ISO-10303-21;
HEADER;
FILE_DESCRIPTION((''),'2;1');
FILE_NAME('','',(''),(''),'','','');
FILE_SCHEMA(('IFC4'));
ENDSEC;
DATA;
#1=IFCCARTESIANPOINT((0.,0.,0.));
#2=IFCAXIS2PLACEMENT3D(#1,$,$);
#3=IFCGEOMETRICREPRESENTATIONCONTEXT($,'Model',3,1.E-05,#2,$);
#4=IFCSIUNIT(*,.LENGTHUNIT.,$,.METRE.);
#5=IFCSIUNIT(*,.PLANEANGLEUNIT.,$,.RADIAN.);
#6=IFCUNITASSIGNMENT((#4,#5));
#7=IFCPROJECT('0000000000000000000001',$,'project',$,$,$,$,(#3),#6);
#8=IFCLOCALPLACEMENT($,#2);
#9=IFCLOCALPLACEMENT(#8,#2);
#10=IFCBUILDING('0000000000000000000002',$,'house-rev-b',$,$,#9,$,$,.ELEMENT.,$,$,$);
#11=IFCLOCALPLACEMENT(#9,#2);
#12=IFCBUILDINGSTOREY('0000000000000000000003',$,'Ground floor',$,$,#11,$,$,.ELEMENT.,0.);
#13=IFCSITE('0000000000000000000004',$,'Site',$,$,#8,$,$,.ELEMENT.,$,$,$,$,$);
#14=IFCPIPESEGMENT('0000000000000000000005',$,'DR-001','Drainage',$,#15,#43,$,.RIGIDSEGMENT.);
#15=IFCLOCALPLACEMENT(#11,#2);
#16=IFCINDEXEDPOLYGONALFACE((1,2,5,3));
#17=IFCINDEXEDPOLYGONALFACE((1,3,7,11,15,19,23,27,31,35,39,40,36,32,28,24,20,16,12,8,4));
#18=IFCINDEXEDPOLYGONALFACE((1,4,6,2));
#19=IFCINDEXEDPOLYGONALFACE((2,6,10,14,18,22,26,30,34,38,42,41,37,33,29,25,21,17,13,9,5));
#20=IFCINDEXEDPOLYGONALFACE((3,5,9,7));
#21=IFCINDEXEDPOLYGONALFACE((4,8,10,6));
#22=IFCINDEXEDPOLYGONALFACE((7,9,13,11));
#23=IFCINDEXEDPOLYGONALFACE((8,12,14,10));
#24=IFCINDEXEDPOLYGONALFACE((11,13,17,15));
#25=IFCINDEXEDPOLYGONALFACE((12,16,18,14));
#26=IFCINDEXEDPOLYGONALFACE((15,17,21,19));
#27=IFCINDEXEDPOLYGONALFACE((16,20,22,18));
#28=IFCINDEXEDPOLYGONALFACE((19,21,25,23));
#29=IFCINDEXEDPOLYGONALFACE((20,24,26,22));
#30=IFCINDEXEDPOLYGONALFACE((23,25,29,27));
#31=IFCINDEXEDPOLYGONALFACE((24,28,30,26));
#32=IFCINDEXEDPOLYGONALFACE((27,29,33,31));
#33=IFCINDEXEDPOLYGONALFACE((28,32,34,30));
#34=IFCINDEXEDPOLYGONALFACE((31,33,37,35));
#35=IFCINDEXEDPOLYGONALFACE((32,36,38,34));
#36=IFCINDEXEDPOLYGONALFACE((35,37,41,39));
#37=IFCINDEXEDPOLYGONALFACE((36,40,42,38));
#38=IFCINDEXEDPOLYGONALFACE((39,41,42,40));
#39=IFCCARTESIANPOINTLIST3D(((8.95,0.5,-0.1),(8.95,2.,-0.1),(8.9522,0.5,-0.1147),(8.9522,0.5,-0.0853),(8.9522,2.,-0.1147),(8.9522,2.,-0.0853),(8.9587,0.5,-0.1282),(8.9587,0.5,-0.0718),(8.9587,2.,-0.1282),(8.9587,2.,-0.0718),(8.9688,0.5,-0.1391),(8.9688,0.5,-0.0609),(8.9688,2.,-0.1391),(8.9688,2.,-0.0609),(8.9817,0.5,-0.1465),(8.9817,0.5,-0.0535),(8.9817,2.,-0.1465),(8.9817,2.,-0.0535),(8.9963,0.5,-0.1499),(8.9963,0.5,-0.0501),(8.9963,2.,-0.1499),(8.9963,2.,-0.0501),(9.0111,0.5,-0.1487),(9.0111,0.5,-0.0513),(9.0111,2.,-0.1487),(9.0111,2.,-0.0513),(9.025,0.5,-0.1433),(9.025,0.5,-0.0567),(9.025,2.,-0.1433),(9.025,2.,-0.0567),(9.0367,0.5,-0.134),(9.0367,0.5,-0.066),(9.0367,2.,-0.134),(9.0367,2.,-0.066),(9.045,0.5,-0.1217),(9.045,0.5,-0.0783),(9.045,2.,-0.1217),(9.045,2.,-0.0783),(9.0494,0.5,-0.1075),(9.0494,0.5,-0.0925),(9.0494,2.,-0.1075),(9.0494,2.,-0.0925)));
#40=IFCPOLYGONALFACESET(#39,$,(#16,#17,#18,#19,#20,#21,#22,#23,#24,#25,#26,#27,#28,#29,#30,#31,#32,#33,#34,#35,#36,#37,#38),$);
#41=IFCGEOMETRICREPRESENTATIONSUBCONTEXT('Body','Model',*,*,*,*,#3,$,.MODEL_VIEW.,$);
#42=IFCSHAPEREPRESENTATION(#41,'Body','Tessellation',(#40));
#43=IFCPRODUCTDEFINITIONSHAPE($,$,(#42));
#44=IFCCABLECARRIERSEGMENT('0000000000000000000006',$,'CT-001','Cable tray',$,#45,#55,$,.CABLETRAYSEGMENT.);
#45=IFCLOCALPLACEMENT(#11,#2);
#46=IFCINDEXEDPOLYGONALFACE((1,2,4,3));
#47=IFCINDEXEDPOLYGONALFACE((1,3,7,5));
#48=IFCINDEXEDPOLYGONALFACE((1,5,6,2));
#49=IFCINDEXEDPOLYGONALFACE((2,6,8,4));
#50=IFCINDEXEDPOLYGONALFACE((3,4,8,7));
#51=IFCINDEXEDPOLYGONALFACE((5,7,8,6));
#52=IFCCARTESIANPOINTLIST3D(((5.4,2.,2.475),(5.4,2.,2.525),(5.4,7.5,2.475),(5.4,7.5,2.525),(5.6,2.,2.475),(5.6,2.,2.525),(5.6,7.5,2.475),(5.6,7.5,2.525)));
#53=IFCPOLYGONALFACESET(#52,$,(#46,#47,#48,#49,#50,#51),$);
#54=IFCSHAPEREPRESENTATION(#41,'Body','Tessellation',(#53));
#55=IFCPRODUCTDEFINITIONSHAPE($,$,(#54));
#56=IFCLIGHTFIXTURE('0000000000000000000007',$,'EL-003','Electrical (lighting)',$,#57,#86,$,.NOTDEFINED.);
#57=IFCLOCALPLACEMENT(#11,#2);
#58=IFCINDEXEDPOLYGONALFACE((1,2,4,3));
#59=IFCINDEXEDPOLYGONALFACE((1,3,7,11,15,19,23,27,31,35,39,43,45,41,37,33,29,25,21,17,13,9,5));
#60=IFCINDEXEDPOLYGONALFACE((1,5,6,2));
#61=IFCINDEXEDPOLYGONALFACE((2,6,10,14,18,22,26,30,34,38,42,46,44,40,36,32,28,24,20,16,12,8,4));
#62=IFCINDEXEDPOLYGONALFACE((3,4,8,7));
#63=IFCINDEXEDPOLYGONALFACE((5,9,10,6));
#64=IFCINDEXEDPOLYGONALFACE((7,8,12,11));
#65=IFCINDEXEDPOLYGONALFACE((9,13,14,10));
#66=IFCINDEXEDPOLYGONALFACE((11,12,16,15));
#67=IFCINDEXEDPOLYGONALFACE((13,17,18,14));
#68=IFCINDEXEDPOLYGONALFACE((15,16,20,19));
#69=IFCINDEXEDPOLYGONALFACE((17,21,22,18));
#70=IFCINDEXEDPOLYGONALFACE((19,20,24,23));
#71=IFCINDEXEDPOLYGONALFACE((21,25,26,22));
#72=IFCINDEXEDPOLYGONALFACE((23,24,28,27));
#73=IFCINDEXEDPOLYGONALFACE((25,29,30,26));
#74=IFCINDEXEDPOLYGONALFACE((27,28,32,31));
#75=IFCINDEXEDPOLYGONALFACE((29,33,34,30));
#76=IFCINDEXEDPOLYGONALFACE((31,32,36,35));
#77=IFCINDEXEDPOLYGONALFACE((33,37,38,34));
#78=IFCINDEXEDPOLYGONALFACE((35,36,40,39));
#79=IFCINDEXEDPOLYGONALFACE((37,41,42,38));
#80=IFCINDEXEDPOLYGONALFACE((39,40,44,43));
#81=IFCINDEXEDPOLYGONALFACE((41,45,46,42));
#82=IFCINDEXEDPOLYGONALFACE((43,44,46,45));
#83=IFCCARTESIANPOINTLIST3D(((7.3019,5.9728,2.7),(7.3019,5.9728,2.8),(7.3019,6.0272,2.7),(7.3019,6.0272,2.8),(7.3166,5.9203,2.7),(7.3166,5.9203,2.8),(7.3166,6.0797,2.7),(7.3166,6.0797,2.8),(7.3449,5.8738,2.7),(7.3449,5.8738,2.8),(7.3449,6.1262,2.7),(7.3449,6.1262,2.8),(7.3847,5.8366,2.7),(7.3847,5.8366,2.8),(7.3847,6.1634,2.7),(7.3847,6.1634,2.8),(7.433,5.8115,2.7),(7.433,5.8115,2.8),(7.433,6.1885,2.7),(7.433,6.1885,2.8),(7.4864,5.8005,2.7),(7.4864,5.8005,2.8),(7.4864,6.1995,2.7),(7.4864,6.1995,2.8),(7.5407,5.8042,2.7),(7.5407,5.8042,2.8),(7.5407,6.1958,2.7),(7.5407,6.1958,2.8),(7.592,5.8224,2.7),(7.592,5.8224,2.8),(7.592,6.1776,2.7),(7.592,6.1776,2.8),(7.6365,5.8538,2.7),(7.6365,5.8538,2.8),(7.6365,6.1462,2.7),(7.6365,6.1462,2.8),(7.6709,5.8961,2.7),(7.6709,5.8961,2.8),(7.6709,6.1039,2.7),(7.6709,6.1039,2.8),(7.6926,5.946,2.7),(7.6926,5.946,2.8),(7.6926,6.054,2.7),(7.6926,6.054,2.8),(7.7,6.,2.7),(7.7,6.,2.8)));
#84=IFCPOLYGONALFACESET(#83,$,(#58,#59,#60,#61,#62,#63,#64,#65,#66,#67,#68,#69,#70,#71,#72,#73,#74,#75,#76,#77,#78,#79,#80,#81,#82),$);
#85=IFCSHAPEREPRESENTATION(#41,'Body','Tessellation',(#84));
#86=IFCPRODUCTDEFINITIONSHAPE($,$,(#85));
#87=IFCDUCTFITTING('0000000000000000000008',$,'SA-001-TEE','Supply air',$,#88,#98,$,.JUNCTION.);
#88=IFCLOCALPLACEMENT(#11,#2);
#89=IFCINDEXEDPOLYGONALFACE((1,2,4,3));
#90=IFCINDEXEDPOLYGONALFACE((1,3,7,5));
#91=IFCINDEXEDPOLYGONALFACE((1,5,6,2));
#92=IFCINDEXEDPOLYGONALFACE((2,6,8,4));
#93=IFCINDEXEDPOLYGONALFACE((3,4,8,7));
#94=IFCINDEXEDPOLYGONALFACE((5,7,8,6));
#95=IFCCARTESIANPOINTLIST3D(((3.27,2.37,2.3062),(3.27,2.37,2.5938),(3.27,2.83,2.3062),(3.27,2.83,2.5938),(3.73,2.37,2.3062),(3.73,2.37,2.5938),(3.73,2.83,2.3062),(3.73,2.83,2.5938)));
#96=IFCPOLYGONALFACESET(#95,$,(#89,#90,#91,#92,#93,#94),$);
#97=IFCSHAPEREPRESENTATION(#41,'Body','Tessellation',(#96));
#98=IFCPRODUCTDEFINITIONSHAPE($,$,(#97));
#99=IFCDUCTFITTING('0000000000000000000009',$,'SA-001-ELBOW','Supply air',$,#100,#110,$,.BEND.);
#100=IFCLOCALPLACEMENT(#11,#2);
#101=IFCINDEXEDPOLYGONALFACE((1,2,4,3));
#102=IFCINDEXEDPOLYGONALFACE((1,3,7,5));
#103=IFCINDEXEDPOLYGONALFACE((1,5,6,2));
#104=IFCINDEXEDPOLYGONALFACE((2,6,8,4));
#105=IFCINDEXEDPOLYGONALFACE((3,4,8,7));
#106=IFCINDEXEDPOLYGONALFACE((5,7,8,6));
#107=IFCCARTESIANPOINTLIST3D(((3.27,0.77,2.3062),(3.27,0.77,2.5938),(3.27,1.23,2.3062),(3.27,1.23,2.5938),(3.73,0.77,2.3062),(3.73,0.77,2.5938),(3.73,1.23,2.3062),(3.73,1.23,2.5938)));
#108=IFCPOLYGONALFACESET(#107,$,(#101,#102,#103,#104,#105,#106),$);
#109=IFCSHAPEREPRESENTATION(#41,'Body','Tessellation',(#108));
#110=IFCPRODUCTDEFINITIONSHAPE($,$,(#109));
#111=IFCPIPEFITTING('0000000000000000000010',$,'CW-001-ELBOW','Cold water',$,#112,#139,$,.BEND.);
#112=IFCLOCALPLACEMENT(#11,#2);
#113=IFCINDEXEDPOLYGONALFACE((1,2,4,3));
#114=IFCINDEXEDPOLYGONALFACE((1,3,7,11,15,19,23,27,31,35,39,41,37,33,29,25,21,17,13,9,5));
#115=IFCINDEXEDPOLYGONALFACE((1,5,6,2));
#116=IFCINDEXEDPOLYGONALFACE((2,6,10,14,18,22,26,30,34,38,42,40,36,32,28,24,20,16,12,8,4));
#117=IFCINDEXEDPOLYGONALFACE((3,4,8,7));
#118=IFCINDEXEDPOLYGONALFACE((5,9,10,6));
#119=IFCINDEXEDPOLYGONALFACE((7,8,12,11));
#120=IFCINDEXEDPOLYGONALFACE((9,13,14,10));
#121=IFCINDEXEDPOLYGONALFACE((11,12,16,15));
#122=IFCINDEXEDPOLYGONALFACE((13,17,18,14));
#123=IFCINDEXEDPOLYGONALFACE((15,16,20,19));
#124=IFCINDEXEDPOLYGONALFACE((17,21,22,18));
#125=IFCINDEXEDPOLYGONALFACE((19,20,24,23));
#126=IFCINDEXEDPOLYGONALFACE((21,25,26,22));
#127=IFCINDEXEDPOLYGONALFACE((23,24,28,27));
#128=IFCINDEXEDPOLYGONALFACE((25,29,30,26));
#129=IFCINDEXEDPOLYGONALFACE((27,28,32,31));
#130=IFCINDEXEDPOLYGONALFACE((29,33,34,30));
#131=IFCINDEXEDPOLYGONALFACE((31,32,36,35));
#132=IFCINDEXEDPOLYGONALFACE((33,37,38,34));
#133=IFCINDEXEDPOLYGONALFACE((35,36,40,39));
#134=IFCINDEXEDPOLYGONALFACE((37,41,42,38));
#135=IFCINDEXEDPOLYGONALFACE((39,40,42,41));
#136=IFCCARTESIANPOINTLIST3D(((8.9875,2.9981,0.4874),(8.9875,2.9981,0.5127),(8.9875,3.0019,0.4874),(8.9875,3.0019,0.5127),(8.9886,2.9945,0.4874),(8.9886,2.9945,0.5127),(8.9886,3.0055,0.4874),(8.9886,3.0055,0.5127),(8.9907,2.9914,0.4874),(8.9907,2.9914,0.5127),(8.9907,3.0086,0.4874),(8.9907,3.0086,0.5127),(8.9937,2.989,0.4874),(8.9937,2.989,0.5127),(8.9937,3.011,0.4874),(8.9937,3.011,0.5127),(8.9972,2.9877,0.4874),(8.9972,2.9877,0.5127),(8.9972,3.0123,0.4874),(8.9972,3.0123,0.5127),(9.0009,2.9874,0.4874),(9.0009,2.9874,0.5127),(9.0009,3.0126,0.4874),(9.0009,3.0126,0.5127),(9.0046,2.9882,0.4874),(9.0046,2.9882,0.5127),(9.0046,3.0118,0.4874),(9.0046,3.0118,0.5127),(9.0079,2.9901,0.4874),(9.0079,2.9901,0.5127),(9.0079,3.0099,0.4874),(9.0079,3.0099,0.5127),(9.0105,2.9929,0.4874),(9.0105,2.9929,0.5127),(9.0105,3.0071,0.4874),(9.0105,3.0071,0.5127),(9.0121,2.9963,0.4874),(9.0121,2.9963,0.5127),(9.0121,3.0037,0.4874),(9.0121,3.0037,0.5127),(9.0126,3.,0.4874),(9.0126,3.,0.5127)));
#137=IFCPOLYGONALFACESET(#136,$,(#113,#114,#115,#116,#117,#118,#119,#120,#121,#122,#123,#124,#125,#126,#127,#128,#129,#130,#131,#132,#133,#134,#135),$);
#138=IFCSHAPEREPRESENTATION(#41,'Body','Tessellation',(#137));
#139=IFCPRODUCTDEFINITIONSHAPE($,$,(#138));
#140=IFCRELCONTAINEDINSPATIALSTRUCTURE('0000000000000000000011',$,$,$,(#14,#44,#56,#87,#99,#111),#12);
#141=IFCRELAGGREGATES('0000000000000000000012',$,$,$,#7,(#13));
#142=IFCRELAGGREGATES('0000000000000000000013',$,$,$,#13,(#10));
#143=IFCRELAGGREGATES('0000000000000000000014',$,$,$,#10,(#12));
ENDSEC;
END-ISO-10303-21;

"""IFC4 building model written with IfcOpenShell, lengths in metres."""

from ifc_helpers import new_model, si_unit, frame, origin, origin_2d, place, context, subcontext, project, spatial, rectangle, circle, extrude, element, save


model = new_model("IFC4")

# Units and contexts
model_context = context("Model", 3, precision=1e-05, world=origin())
body_context = subcontext(model_context, "Body", "Model", "MODEL_VIEW")
ifc_project = project(units=[si_unit("LENGTHUNIT", "METRE"), si_unit("PLANEANGLEUNIT", "RADIAN")], contexts=[model_context])

# Site, building, storey
site_placement = place(None, origin())
site = spatial("IfcSite", under=ifc_project, at=site_placement, Name="Site", CompositionType="ELEMENT")
building_placement = place(site_placement, origin())
building = spatial("IfcBuilding", under=site, at=building_placement, Name="house-rev-b", CompositionType="ELEMENT")
storey_placement = place(building_placement, origin())
storey = spatial("IfcBuildingStorey", under=building, at=storey_placement, Name="Ground floor", CompositionType="ELEMENT", Elevation=0.0)

# Pipe segment
pipe_segment_1_placement = place(storey_placement, frame((9.0, 0.5, -0.1), z_axis=(0.0, 1.0, 0.0), x_axis=(-1.0, 0.0, 0.0)))
element("IfcPipeSegment", 1, at=pipe_segment_1_placement, inside=storey, Name="DR-001", Description="Drainage", PredefinedType="RIGIDSEGMENT", context=body_context, shape_type="SweptSolid", body=[
    extrude(circle(Radius=0.05, at=origin_2d()), origin(), (0.0, 0.0, 1.0), 1.5),
])

# Cable carrier segment
cable_carrier_segment_placement = place(storey_placement, frame((5.5, 2.0, 2.5), z_axis=(0.0, 1.0, 0.0), x_axis=(-1.0, 0.0, 0.0)))
element("IfcCableCarrierSegment", 2, at=cable_carrier_segment_placement, inside=storey, Name="CT-001", Description="Cable tray", PredefinedType="CABLETRAYSEGMENT", context=body_context, shape_type="SweptSolid", body=[
    extrude(rectangle(XDim=0.2, YDim=0.05, at=origin_2d()), origin(), (0.0, 0.0, 1.0), 5.5),
])

# Light fixture
light_fixture_placement = place(storey_placement, frame((7.5, 6.0, 2.7), z_axis=(0.0, 0.0, 1.0), x_axis=(1.0, 0.0, 0.0)))
element("IfcLightFixture", 3, at=light_fixture_placement, inside=storey, Name="EL-003", Description="Electrical (lighting)", PredefinedType="NOTDEFINED", context=body_context, shape_type="SweptSolid", body=[
    extrude(circle(Radius=0.2, at=origin_2d()), origin(), (0.0, 0.0, 1.0), 0.1),
])

# Duct fittings
duct_fitting_1_placement = place(storey_placement, frame((3.5, 2.6, 2.3062), z_axis=(0.0, 0.0, 1.0), x_axis=(1.0, 0.0, 0.0)))
element("IfcDuctFitting", 4, at=duct_fitting_1_placement, inside=storey, Name="SA-001-TEE", Description="Supply air", PredefinedType="JUNCTION", context=body_context, shape_type="SweptSolid", body=[
    extrude(rectangle(XDim=0.46, YDim=0.46, at=origin_2d()), origin(), (0.0, 0.0, 1.0), 0.2875),
])
duct_fitting_2_placement = place(storey_placement, frame((3.5, 1.0, 2.3062), z_axis=(0.0, 0.0, 1.0), x_axis=(1.0, 0.0, 0.0)))
element("IfcDuctFitting", 5, at=duct_fitting_2_placement, inside=storey, Name="SA-001-ELBOW", Description="Supply air", PredefinedType="BEND", context=body_context, shape_type="SweptSolid", body=[
    extrude(rectangle(XDim=0.46, YDim=0.46, at=origin_2d()), origin(), (0.0, 0.0, 1.0), 0.2875),
])

# Pipe fitting
pipe_fitting_placement = place(storey_placement, frame((9.0, 3.0, 0.4874), z_axis=(0.0, 0.0, 1.0), x_axis=(1.0, 0.0, 0.0)))
element("IfcPipeFitting", 6, at=pipe_fitting_placement, inside=storey, Name="CW-001-ELBOW", Description="Cold water", PredefinedType="BEND", context=body_context, shape_type="SweptSolid", body=[
    extrude(circle(Radius=0.0126, at=origin_2d()), origin(), (0.0, 0.0, 1.0), 0.0253),
])

save(model, "model.ifc")
